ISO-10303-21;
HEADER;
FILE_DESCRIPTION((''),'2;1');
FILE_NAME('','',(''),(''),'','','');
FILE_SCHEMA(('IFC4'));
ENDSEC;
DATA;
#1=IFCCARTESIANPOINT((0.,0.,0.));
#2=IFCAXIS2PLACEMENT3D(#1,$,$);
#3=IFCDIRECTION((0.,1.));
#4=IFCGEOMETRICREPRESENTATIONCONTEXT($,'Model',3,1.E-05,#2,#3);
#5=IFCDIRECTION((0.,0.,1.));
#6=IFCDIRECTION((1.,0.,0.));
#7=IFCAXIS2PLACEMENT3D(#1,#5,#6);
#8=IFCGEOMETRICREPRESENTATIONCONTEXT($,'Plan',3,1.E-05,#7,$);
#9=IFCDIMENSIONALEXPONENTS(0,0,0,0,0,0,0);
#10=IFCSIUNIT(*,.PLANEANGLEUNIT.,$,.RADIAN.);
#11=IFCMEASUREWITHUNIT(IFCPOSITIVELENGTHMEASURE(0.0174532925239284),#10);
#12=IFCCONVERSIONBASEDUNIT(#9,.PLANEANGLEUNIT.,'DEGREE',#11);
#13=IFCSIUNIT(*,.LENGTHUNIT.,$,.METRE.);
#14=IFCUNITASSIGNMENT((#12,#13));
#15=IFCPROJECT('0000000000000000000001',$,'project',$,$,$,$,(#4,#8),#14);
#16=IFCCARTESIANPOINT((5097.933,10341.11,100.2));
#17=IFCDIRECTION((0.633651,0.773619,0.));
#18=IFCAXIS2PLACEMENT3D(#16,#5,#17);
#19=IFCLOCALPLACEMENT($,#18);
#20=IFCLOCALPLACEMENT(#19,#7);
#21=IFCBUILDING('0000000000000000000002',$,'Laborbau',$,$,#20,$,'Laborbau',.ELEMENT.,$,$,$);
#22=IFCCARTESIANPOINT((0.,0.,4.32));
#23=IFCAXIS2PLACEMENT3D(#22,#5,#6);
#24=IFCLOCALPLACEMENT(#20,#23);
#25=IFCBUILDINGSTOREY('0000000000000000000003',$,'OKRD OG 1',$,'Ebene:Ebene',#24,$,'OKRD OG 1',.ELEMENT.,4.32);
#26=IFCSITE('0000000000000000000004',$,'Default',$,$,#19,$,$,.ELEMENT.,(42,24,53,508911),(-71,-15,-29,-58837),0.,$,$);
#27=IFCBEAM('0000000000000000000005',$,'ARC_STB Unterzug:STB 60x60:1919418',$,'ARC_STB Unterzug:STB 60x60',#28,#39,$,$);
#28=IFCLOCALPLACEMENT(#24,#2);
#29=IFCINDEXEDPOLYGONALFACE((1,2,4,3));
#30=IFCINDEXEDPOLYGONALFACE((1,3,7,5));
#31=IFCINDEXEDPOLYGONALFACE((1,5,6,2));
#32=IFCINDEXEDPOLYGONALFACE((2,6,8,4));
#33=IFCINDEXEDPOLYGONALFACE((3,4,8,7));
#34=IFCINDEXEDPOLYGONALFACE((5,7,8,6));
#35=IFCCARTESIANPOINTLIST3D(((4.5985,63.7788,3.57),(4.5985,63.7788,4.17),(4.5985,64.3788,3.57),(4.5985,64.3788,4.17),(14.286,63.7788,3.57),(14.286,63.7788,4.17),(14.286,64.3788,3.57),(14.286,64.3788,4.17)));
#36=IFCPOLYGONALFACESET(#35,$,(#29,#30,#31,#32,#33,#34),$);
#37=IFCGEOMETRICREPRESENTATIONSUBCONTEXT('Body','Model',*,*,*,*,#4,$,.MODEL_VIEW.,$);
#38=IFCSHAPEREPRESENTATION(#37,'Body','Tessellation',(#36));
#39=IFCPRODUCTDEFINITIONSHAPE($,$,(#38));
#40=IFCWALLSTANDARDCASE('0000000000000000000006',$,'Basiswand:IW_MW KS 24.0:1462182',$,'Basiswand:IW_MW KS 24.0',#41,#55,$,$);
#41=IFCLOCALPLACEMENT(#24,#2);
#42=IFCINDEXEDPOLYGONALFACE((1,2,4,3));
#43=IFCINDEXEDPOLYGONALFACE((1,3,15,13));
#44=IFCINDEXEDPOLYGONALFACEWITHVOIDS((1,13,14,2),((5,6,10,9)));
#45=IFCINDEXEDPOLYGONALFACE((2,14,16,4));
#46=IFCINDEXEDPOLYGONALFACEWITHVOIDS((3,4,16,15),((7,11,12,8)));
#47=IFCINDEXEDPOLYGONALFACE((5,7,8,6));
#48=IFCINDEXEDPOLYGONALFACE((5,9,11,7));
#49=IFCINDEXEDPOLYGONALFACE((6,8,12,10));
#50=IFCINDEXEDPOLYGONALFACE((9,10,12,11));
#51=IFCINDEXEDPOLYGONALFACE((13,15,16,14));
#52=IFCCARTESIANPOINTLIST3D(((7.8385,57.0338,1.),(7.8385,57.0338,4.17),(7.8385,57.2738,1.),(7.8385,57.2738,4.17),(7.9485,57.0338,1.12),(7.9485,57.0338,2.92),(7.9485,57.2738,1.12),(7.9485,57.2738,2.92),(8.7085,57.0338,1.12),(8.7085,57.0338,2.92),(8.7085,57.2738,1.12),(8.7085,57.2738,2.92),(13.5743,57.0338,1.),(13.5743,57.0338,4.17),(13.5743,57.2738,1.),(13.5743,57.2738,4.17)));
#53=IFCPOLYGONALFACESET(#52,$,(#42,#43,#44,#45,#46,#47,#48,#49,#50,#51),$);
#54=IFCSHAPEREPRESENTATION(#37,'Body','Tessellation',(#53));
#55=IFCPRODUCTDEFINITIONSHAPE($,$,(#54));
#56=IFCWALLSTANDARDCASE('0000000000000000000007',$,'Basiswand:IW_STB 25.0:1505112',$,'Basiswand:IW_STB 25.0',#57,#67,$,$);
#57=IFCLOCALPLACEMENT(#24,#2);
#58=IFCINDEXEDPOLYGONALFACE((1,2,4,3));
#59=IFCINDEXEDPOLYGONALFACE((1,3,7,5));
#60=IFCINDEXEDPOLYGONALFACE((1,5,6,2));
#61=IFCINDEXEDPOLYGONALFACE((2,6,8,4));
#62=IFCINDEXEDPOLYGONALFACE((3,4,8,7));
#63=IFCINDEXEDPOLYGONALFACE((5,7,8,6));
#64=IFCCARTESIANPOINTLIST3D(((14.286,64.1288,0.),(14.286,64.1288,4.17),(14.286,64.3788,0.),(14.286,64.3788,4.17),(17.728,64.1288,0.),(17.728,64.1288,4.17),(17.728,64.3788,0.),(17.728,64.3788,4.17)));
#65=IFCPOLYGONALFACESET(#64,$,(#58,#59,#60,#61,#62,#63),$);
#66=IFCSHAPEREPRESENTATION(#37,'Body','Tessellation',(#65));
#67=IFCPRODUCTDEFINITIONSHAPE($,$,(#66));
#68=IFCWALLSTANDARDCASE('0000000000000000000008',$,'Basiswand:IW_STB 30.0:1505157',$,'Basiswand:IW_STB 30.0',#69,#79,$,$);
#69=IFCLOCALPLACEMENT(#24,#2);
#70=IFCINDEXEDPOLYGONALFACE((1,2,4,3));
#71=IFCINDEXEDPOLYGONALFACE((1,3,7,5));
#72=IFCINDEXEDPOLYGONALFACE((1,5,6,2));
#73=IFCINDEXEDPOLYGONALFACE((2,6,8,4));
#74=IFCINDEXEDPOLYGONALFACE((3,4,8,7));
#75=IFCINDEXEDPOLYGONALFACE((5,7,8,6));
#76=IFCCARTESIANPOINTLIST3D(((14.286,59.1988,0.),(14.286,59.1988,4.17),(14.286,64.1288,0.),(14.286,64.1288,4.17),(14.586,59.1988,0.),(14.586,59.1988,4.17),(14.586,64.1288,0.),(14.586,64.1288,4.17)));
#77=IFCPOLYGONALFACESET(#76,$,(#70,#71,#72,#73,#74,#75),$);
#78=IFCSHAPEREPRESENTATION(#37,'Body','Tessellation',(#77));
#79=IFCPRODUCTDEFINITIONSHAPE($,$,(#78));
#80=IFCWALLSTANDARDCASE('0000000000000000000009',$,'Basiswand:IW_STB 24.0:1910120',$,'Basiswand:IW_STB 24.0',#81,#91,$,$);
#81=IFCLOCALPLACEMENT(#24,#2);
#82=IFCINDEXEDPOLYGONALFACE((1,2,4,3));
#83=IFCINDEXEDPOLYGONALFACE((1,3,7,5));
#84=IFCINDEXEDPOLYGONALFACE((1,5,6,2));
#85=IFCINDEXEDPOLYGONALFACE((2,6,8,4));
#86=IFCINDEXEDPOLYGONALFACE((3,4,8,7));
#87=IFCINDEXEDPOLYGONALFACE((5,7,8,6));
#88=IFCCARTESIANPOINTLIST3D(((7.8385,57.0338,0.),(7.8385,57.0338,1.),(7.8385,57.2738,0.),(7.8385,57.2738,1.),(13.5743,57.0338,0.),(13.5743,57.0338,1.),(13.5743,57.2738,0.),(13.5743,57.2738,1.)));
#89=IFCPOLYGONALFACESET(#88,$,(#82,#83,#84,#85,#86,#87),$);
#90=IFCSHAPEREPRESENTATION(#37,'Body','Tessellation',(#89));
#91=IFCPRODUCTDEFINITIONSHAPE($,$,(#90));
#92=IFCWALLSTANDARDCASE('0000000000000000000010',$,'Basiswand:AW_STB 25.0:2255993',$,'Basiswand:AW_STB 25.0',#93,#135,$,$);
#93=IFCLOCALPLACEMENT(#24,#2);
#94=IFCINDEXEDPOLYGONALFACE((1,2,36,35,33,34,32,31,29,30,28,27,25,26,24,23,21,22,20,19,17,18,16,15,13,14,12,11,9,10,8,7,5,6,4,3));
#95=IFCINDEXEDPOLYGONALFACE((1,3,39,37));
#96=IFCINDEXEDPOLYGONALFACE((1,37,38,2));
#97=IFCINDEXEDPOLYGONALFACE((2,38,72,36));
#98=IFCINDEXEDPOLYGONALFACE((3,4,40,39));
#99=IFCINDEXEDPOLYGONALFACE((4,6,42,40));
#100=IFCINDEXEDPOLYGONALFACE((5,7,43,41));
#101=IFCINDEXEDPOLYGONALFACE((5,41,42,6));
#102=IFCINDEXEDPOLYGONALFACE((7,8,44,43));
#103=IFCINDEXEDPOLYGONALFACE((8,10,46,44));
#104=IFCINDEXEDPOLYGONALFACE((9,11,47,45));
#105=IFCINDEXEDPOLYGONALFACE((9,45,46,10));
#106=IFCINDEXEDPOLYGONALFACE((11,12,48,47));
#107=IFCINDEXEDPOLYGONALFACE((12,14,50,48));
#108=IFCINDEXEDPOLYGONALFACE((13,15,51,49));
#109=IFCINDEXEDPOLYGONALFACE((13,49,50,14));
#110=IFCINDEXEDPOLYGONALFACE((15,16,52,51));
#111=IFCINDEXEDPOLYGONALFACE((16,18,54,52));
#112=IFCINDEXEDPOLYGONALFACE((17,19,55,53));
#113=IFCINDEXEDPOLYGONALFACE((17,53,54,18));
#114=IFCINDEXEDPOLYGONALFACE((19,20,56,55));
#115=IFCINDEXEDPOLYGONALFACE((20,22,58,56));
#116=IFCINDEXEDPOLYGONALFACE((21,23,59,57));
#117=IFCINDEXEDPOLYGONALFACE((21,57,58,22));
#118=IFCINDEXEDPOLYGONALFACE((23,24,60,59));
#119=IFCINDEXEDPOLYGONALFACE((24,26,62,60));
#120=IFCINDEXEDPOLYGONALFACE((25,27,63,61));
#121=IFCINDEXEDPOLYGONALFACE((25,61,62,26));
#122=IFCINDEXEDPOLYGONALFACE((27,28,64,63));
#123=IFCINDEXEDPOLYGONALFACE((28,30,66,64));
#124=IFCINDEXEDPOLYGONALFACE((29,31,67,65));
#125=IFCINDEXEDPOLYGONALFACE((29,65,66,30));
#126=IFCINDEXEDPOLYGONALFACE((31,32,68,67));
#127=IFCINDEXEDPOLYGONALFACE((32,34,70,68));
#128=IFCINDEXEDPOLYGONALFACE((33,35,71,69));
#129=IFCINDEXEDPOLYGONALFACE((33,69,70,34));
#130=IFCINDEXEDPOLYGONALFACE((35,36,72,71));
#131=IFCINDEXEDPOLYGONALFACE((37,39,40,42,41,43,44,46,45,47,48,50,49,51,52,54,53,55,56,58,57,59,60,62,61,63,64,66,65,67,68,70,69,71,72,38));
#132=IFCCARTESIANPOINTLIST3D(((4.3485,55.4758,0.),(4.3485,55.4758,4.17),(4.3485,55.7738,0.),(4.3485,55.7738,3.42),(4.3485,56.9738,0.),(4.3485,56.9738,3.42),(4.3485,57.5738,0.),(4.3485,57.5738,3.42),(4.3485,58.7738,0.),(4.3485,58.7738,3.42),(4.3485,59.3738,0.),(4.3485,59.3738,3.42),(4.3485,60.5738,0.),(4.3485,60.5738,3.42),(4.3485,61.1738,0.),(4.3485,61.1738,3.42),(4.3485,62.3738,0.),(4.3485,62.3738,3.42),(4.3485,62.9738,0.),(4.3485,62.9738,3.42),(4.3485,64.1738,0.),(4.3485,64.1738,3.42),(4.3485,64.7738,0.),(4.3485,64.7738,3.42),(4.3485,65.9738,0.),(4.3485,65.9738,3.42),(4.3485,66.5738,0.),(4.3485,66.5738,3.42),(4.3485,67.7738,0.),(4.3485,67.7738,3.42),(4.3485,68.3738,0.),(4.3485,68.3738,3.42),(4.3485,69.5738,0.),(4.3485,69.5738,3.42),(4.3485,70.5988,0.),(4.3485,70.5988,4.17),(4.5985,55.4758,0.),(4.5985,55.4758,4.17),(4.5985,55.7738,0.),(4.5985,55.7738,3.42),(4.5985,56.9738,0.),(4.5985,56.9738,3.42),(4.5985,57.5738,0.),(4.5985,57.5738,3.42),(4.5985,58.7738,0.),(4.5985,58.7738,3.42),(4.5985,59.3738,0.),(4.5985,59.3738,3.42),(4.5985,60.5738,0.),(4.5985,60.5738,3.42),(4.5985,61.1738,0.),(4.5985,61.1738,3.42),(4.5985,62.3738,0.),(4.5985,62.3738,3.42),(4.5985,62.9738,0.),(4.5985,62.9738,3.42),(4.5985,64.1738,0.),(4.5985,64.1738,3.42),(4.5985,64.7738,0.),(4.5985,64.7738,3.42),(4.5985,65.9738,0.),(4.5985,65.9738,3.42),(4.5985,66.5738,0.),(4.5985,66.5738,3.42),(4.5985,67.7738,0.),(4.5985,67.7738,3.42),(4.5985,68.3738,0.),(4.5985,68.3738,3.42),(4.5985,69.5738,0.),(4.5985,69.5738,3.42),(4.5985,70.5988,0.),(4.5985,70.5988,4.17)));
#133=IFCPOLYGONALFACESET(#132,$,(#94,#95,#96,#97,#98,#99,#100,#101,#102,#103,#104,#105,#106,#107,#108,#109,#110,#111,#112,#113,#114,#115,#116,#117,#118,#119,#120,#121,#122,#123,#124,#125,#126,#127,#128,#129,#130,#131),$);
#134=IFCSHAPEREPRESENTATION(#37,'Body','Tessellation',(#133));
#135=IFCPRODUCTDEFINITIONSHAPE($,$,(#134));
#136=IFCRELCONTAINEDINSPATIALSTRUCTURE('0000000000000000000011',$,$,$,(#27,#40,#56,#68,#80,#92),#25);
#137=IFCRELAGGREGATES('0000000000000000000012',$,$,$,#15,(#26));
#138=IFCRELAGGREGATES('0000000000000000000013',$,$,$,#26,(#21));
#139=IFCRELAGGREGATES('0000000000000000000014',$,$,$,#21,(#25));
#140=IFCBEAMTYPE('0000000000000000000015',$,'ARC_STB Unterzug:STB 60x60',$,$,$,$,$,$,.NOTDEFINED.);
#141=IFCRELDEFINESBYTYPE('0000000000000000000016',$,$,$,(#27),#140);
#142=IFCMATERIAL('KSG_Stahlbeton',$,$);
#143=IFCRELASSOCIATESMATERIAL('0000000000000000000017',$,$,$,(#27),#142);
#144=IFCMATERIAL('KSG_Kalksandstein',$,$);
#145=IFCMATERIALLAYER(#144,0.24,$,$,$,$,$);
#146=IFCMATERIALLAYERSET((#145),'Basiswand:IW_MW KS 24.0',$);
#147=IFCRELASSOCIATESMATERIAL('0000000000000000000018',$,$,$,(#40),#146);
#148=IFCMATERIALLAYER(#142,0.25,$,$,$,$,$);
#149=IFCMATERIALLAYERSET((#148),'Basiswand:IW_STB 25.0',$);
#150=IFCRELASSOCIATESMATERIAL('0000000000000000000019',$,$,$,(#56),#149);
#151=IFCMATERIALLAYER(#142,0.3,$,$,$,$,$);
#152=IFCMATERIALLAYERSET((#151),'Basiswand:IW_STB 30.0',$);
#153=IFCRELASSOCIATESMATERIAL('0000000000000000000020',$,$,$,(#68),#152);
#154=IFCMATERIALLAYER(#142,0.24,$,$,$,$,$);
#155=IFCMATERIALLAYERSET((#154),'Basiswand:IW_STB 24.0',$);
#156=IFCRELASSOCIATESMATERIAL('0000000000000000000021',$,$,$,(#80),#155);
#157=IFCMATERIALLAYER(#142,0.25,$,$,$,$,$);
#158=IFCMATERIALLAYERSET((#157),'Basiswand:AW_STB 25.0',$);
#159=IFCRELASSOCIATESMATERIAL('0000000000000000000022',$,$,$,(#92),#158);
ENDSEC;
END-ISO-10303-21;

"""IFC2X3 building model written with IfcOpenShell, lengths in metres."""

from ifc_helpers import new_model, entity, si_unit, converted_unit, direction, frame, frame_2d, origin, origin_with_axes, place, context, subcontext, project, spatial, rectangle, extrude, material, layer, layer_set, layer_usage, type_object, element, save


model = new_model("IFC2X3")

# Units and contexts
model_context = context("Model", 3, precision=1e-05, world=origin(), true_north=direction((0.0, 1.0)))
plan_context = context("Plan", 3, precision=1e-05, world=origin_with_axes())
body_context = subcontext(model_context, "Body", "Model", "MODEL_VIEW")
ifc_project = project(units=[converted_unit("PLANEANGLEUNIT", "DEGREE", entity("IfcPositiveLengthMeasure", 0.0174532925239284), si_unit("PLANEANGLEUNIT", "RADIAN"), dimensions=[0, 0, 0, 0, 0, 0, 0]), si_unit("LENGTHUNIT", "METRE")], contexts=[model_context, plan_context])

# Site, building, storey
site_placement = place(None, frame((5097.933, 10341.11, 100.2), z_axis=(0.0, 0.0, 1.0), x_axis=(0.633651, 0.773619, 0.0)))
site = spatial("IfcSite", under=ifc_project, at=site_placement, Name="Default", CompositionType="ELEMENT", RefLatitude=(42, 24, 53, 508911), RefLongitude=(-71, -15, -29, -58837), RefElevation=0.0)
building_placement = place(site_placement, origin_with_axes())
building = spatial("IfcBuilding", under=site, at=building_placement, Name="Laborbau", LongName="Laborbau", CompositionType="ELEMENT")
storey_placement = place(building_placement, frame((0.0, 0.0, 4.32), z_axis=(0.0, 0.0, 1.0), x_axis=(1.0, 0.0, 0.0)))
storey = spatial("IfcBuildingStorey", under=building, at=storey_placement, Name="OKRD OG 1", ObjectType="Ebene:Ebene", LongName="OKRD OG 1", CompositionType="ELEMENT", Elevation=4.32)

# Beam
ifc_material_1 = material(Name="KSG_Stahlbeton")
beam_type_1 = type_object("IfcBeamType", Name="ARC_STB Unterzug:STB 60x60", PredefinedType="NOTDEFINED")
beam_1_placement = place(storey_placement, frame((4.4735, 64.0788, 4.17), z_axis=(0.0, 0.0, 1.0), x_axis=(1.0, 0.0, 0.0)))
element("IfcBeam", 1, at=beam_1_placement, inside=storey, type_object=beam_type_1, material=ifc_material_1, Name="ARC_STB Unterzug:STB 60x60:1919418", ObjectType="ARC_STB Unterzug:STB 60x60", context=body_context, shape_type="SweptSolid", body=[
    extrude(rectangle(XDim=0.6, YDim=0.6, at=frame_2d((0.0, 0.0), x_axis=(1.0, 0.0))), frame((0.125, 0.0, -0.3), z_axis=(1.0, 0.0, 0.0), x_axis=(0.0, 0.0, -1.0)), (0.0, 0.0, 1.0), 9.6875),
])

# Wall, openings
ifc_layer_1 = layer(ifc_material_1, 0.25)
ifc_layer_set_1 = layer_set([ifc_layer_1], Name="Basiswand:AW_STB 25.0")
ifc_material_2 = material(Name="KSG_Kalksandstein")
ifc_layer_2 = layer(ifc_material_2, 0.24)
ifc_layer_set_2 = layer_set([ifc_layer_2], Name="Basiswand:IW_MW KS 24.0")
ifc_layer_usage_1 = layer_usage(ifc_layer_set_2, "AXIS2", "NEGATIVE", 0.12)
wall_1_placement = place(storey_placement, frame((7.8385, 57.1538, 1.0), z_axis=(0.0, 0.0, 1.0), x_axis=(1.0, 0.0, 0.0)))
wall_1 = element("IfcWallStandardCase", 2, at=wall_1_placement, inside=storey, material=ifc_layer_usage_1, Name="Basiswand:IW_MW KS 24.0:1462182", ObjectType="Basiswand:IW_MW KS 24.0", context=body_context, shape_type="SweptSolid", body=[
    extrude(rectangle(XDim=5.7358, YDim=0.24, at=frame_2d((2.8679, 0.0), x_axis=(-1.0, 0.0))), origin(), (0.0, 0.0, 1.0), 3.17),
])
opening_1_placement = place(wall_1_placement, frame((-7.8385, -57.1538, -1.0), z_axis=(0.0, 0.0, 1.0), x_axis=(1.0, 0.0, 0.0)))
element("IfcOpeningElement", 3, at=opening_1_placement, cuts=wall_1, ObjectType="Opening", context=body_context, shape_type="SweptSolid", body=[
    extrude(rectangle(XDim=1.8, YDim=0.76, at=frame_2d((0.0, 0.0), x_axis=(0.0, 1.0))), frame((8.3285, 55.5098, 2.02), z_axis=(0.0, 1.0, 0.0), x_axis=(-1.0, 0.0, 0.0)), (0.0, 0.0, 1.0), 3.048),
])
opening_2_placement = place(wall_1_placement, frame((0.11, -0.12, 0.12), z_axis=(0.0, 0.0, 1.0), x_axis=(1.0, 0.0, 0.0)))
element("IfcOpeningElement", 4, at=opening_2_placement, cuts=wall_1, ObjectType="Opening", context=body_context, shape_type="SweptSolid", body=[
    extrude(rectangle(XDim=1.8, YDim=0.76, at=frame_2d((0.9, 0.38), x_axis=(1.0, 0.0))), frame((0.0, 0.0, 0.0), z_axis=(0.0, 1.0, 0.0), x_axis=(0.0, 0.0, 1.0)), (0.0, 0.0, 1.0), 0.24),
])

# Walls
ifc_layer_3 = layer(ifc_material_1, 0.25)
ifc_layer_set_3 = layer_set([ifc_layer_3], Name="Basiswand:IW_STB 25.0")
ifc_layer_usage_2 = layer_usage(ifc_layer_set_3, "AXIS2", "POSITIVE", -0.125)
wall_2_placement = place(storey_placement, frame((14.286, 64.2538, 0.0), z_axis=(0.0, 0.0, 1.0), x_axis=(1.0, 0.0, 0.0)))
element("IfcWallStandardCase", 5, at=wall_2_placement, inside=storey, material=ifc_layer_usage_2, Name="Basiswand:IW_STB 25.0:1505112", ObjectType="Basiswand:IW_STB 25.0", context=body_context, shape_type="SweptSolid", body=[
    extrude(rectangle(XDim=3.442, YDim=0.25, at=frame_2d((1.721, 0.0), x_axis=(-1.0, 0.0))), origin(), (0.0, 0.0, 1.0), 4.17),
])
ifc_layer_4 = layer(ifc_material_1, 0.3)
ifc_layer_set_4 = layer_set([ifc_layer_4], Name="Basiswand:IW_STB 30.0")
ifc_layer_usage_3 = layer_usage(ifc_layer_set_4, "AXIS2", "NEGATIVE", 0.15)
wall_3_placement = place(storey_placement, frame((14.436, 64.1288, 0.0), z_axis=(0.0, 0.0, 1.0), x_axis=(0.0, -1.0, 0.0)))
element("IfcWallStandardCase", 6, at=wall_3_placement, inside=storey, material=ifc_layer_usage_3, Name="Basiswand:IW_STB 30.0:1505157", ObjectType="Basiswand:IW_STB 30.0", context=body_context, shape_type="SweptSolid", body=[
    extrude(rectangle(XDim=4.93, YDim=0.3, at=frame_2d((2.465, 0.0), x_axis=(-1.0, 0.0))), origin(), (0.0, 0.0, 1.0), 4.17),
])
ifc_layer_5 = layer(ifc_material_1, 0.24)
ifc_layer_set_5 = layer_set([ifc_layer_5], Name="Basiswand:IW_STB 24.0")
ifc_layer_usage_4 = layer_usage(ifc_layer_set_5, "AXIS2", "NEGATIVE", 0.12)
wall_4_placement = place(storey_placement, frame((7.8385, 57.1538, 0.0), z_axis=(0.0, 0.0, 1.0), x_axis=(1.0, 0.0, 0.0)))
element("IfcWallStandardCase", 7, at=wall_4_placement, inside=storey, material=ifc_layer_usage_4, Name="Basiswand:IW_STB 24.0:1910120", ObjectType="Basiswand:IW_STB 24.0", context=body_context, shape_type="SweptSolid", body=[
    extrude(rectangle(XDim=5.7358, YDim=0.24, at=frame_2d((2.8679, 0.0), x_axis=(-1.0, 0.0))), origin(), (0.0, 0.0, 1.0), 1.0),
])

# Wall, openings
ifc_layer_usage_5 = layer_usage(ifc_layer_set_1, "AXIS2", "NEGATIVE", 0.125)
wall_5_placement = place(storey_placement, frame((4.4735, 55.4758, 0.0), z_axis=(0.0, 0.0, 1.0), x_axis=(0.0, 1.0, 0.0)))
wall_5 = element("IfcWallStandardCase", 8, at=wall_5_placement, inside=storey, material=ifc_layer_usage_5, Name="Basiswand:AW_STB 25.0:2255993", ObjectType="Basiswand:AW_STB 25.0", context=body_context, shape_type="SweptSolid", body=[
    extrude(rectangle(XDim=15.123, YDim=0.25, at=frame_2d((7.5615, 0.0), x_axis=(-1.0, 0.0))), origin(), (0.0, 0.0, 1.0), 4.17),
])
opening_3_placement = place(wall_5_placement, frame((-55.4758, 4.4735, 0.0), z_axis=(0.0, 0.0, 1.0), x_axis=(0.0, -1.0, 0.0)))
element("IfcOpeningElement", 9, at=opening_3_placement, cuts=wall_5, ObjectType="Opening", context=body_context, shape_type="SweptSolid", body=[
    extrude(rectangle(XDim=3.42, YDim=1.2, at=frame_2d((0.0, 0.0), x_axis=(0.0, 1.0))), frame((4.5985, 61.7738, 1.71), z_axis=(-1.0, 0.0, 0.0), x_axis=(0.0, 1.0, 0.0)), (0.0, 0.0, 1.0), 0.25),
])
opening_4_placement = place(wall_5_placement, frame((-55.4758, 4.4735, 0.0), z_axis=(0.0, 0.0, 1.0), x_axis=(0.0, -1.0, 0.0)))
element("IfcOpeningElement", 10, at=opening_4_placement, cuts=wall_5, ObjectType="Opening", context=body_context, shape_type="SweptSolid", body=[
    extrude(rectangle(XDim=3.42, YDim=1.2, at=frame_2d((0.0, 0.0), x_axis=(1.0, 0.0))), frame((4.5985, 59.9738, 1.71), z_axis=(-1.0, 0.0, 0.0), x_axis=(0.0, 0.0, -1.0)), (0.0, 0.0, 1.0), 0.25),
])
opening_5_placement = place(wall_5_placement, frame((-55.4758, 4.4735, 0.0), z_axis=(0.0, 0.0, 1.0), x_axis=(0.0, -1.0, 0.0)))
element("IfcOpeningElement", 11, at=opening_5_placement, cuts=wall_5, ObjectType="Opening", context=body_context, shape_type="SweptSolid", body=[
    extrude(rectangle(XDim=3.42, YDim=1.2, at=frame_2d((0.0, 0.0), x_axis=(0.0, 1.0))), frame((4.5985, 58.1738, 1.71), z_axis=(-1.0, 0.0, 0.0), x_axis=(0.0, 1.0, 0.0)), (0.0, 0.0, 1.0), 0.25),
])
opening_6_placement = place(wall_5_placement, frame((-55.4758, 4.4735, 0.0), z_axis=(0.0, 0.0, 1.0), x_axis=(0.0, -1.0, 0.0)))
element("IfcOpeningElement", 12, at=opening_6_placement, cuts=wall_5, ObjectType="Opening", context=body_context, shape_type="SweptSolid", body=[
    extrude(rectangle(XDim=3.42, YDim=1.2, at=frame_2d((0.0, 0.0), x_axis=(1.0, 0.0))), frame((4.5985, 56.3738, 1.71), z_axis=(-1.0, 0.0, 0.0), x_axis=(0.0, 0.0, -1.0)), (0.0, 0.0, 1.0), 0.25),
])
opening_7_placement = place(wall_5_placement, frame((-55.4758, 4.4735, 0.0), z_axis=(0.0, 0.0, 1.0), x_axis=(0.0, -1.0, 0.0)))
element("IfcOpeningElement", 13, at=opening_7_placement, cuts=wall_5, ObjectType="Opening", context=body_context, shape_type="SweptSolid", body=[
    extrude(rectangle(XDim=3.42, YDim=1.2, at=frame_2d((0.0, 0.0), x_axis=(0.0, 1.0))), frame((4.5985, 68.9738, 1.71), z_axis=(-1.0, 0.0, 0.0), x_axis=(0.0, 1.0, 0.0)), (0.0, 0.0, 1.0), 0.25),
])
opening_8_placement = place(wall_5_placement, frame((-55.4758, 4.4735, 0.0), z_axis=(0.0, 0.0, 1.0), x_axis=(0.0, -1.0, 0.0)))
element("IfcOpeningElement", 14, at=opening_8_placement, cuts=wall_5, ObjectType="Opening", context=body_context, shape_type="SweptSolid", body=[
    extrude(rectangle(XDim=3.42, YDim=1.2, at=frame_2d((0.0, 0.0), x_axis=(1.0, 0.0))), frame((4.5985, 67.1738, 1.71), z_axis=(-1.0, 0.0, 0.0), x_axis=(0.0, 0.0, -1.0)), (0.0, 0.0, 1.0), 0.25),
])
opening_9_placement = place(wall_5_placement, frame((-55.4758, 4.4735, 0.0), z_axis=(0.0, 0.0, 1.0), x_axis=(0.0, -1.0, 0.0)))
element("IfcOpeningElement", 15, at=opening_9_placement, cuts=wall_5, ObjectType="Opening", context=body_context, shape_type="SweptSolid", body=[
    extrude(rectangle(XDim=3.42, YDim=1.2, at=frame_2d((0.0, 0.0), x_axis=(0.0, 1.0))), frame((4.5985, 65.3738, 1.71), z_axis=(-1.0, 0.0, 0.0), x_axis=(0.0, 1.0, 0.0)), (0.0, 0.0, 1.0), 0.25),
])
opening_10_placement = place(wall_5_placement, frame((-55.4758, 4.4735, 0.0), z_axis=(0.0, 0.0, 1.0), x_axis=(0.0, -1.0, 0.0)))
element("IfcOpeningElement", 16, at=opening_10_placement, cuts=wall_5, ObjectType="Opening", context=body_context, shape_type="SweptSolid", body=[
    extrude(rectangle(XDim=3.42, YDim=1.2, at=frame_2d((0.0, 0.0), x_axis=(1.0, 0.0))), frame((4.5985, 63.5738, 1.71), z_axis=(-1.0, 0.0, 0.0), x_axis=(0.0, 0.0, -1.0)), (0.0, 0.0, 1.0), 0.25),
])

save(model, "model.ifc")
